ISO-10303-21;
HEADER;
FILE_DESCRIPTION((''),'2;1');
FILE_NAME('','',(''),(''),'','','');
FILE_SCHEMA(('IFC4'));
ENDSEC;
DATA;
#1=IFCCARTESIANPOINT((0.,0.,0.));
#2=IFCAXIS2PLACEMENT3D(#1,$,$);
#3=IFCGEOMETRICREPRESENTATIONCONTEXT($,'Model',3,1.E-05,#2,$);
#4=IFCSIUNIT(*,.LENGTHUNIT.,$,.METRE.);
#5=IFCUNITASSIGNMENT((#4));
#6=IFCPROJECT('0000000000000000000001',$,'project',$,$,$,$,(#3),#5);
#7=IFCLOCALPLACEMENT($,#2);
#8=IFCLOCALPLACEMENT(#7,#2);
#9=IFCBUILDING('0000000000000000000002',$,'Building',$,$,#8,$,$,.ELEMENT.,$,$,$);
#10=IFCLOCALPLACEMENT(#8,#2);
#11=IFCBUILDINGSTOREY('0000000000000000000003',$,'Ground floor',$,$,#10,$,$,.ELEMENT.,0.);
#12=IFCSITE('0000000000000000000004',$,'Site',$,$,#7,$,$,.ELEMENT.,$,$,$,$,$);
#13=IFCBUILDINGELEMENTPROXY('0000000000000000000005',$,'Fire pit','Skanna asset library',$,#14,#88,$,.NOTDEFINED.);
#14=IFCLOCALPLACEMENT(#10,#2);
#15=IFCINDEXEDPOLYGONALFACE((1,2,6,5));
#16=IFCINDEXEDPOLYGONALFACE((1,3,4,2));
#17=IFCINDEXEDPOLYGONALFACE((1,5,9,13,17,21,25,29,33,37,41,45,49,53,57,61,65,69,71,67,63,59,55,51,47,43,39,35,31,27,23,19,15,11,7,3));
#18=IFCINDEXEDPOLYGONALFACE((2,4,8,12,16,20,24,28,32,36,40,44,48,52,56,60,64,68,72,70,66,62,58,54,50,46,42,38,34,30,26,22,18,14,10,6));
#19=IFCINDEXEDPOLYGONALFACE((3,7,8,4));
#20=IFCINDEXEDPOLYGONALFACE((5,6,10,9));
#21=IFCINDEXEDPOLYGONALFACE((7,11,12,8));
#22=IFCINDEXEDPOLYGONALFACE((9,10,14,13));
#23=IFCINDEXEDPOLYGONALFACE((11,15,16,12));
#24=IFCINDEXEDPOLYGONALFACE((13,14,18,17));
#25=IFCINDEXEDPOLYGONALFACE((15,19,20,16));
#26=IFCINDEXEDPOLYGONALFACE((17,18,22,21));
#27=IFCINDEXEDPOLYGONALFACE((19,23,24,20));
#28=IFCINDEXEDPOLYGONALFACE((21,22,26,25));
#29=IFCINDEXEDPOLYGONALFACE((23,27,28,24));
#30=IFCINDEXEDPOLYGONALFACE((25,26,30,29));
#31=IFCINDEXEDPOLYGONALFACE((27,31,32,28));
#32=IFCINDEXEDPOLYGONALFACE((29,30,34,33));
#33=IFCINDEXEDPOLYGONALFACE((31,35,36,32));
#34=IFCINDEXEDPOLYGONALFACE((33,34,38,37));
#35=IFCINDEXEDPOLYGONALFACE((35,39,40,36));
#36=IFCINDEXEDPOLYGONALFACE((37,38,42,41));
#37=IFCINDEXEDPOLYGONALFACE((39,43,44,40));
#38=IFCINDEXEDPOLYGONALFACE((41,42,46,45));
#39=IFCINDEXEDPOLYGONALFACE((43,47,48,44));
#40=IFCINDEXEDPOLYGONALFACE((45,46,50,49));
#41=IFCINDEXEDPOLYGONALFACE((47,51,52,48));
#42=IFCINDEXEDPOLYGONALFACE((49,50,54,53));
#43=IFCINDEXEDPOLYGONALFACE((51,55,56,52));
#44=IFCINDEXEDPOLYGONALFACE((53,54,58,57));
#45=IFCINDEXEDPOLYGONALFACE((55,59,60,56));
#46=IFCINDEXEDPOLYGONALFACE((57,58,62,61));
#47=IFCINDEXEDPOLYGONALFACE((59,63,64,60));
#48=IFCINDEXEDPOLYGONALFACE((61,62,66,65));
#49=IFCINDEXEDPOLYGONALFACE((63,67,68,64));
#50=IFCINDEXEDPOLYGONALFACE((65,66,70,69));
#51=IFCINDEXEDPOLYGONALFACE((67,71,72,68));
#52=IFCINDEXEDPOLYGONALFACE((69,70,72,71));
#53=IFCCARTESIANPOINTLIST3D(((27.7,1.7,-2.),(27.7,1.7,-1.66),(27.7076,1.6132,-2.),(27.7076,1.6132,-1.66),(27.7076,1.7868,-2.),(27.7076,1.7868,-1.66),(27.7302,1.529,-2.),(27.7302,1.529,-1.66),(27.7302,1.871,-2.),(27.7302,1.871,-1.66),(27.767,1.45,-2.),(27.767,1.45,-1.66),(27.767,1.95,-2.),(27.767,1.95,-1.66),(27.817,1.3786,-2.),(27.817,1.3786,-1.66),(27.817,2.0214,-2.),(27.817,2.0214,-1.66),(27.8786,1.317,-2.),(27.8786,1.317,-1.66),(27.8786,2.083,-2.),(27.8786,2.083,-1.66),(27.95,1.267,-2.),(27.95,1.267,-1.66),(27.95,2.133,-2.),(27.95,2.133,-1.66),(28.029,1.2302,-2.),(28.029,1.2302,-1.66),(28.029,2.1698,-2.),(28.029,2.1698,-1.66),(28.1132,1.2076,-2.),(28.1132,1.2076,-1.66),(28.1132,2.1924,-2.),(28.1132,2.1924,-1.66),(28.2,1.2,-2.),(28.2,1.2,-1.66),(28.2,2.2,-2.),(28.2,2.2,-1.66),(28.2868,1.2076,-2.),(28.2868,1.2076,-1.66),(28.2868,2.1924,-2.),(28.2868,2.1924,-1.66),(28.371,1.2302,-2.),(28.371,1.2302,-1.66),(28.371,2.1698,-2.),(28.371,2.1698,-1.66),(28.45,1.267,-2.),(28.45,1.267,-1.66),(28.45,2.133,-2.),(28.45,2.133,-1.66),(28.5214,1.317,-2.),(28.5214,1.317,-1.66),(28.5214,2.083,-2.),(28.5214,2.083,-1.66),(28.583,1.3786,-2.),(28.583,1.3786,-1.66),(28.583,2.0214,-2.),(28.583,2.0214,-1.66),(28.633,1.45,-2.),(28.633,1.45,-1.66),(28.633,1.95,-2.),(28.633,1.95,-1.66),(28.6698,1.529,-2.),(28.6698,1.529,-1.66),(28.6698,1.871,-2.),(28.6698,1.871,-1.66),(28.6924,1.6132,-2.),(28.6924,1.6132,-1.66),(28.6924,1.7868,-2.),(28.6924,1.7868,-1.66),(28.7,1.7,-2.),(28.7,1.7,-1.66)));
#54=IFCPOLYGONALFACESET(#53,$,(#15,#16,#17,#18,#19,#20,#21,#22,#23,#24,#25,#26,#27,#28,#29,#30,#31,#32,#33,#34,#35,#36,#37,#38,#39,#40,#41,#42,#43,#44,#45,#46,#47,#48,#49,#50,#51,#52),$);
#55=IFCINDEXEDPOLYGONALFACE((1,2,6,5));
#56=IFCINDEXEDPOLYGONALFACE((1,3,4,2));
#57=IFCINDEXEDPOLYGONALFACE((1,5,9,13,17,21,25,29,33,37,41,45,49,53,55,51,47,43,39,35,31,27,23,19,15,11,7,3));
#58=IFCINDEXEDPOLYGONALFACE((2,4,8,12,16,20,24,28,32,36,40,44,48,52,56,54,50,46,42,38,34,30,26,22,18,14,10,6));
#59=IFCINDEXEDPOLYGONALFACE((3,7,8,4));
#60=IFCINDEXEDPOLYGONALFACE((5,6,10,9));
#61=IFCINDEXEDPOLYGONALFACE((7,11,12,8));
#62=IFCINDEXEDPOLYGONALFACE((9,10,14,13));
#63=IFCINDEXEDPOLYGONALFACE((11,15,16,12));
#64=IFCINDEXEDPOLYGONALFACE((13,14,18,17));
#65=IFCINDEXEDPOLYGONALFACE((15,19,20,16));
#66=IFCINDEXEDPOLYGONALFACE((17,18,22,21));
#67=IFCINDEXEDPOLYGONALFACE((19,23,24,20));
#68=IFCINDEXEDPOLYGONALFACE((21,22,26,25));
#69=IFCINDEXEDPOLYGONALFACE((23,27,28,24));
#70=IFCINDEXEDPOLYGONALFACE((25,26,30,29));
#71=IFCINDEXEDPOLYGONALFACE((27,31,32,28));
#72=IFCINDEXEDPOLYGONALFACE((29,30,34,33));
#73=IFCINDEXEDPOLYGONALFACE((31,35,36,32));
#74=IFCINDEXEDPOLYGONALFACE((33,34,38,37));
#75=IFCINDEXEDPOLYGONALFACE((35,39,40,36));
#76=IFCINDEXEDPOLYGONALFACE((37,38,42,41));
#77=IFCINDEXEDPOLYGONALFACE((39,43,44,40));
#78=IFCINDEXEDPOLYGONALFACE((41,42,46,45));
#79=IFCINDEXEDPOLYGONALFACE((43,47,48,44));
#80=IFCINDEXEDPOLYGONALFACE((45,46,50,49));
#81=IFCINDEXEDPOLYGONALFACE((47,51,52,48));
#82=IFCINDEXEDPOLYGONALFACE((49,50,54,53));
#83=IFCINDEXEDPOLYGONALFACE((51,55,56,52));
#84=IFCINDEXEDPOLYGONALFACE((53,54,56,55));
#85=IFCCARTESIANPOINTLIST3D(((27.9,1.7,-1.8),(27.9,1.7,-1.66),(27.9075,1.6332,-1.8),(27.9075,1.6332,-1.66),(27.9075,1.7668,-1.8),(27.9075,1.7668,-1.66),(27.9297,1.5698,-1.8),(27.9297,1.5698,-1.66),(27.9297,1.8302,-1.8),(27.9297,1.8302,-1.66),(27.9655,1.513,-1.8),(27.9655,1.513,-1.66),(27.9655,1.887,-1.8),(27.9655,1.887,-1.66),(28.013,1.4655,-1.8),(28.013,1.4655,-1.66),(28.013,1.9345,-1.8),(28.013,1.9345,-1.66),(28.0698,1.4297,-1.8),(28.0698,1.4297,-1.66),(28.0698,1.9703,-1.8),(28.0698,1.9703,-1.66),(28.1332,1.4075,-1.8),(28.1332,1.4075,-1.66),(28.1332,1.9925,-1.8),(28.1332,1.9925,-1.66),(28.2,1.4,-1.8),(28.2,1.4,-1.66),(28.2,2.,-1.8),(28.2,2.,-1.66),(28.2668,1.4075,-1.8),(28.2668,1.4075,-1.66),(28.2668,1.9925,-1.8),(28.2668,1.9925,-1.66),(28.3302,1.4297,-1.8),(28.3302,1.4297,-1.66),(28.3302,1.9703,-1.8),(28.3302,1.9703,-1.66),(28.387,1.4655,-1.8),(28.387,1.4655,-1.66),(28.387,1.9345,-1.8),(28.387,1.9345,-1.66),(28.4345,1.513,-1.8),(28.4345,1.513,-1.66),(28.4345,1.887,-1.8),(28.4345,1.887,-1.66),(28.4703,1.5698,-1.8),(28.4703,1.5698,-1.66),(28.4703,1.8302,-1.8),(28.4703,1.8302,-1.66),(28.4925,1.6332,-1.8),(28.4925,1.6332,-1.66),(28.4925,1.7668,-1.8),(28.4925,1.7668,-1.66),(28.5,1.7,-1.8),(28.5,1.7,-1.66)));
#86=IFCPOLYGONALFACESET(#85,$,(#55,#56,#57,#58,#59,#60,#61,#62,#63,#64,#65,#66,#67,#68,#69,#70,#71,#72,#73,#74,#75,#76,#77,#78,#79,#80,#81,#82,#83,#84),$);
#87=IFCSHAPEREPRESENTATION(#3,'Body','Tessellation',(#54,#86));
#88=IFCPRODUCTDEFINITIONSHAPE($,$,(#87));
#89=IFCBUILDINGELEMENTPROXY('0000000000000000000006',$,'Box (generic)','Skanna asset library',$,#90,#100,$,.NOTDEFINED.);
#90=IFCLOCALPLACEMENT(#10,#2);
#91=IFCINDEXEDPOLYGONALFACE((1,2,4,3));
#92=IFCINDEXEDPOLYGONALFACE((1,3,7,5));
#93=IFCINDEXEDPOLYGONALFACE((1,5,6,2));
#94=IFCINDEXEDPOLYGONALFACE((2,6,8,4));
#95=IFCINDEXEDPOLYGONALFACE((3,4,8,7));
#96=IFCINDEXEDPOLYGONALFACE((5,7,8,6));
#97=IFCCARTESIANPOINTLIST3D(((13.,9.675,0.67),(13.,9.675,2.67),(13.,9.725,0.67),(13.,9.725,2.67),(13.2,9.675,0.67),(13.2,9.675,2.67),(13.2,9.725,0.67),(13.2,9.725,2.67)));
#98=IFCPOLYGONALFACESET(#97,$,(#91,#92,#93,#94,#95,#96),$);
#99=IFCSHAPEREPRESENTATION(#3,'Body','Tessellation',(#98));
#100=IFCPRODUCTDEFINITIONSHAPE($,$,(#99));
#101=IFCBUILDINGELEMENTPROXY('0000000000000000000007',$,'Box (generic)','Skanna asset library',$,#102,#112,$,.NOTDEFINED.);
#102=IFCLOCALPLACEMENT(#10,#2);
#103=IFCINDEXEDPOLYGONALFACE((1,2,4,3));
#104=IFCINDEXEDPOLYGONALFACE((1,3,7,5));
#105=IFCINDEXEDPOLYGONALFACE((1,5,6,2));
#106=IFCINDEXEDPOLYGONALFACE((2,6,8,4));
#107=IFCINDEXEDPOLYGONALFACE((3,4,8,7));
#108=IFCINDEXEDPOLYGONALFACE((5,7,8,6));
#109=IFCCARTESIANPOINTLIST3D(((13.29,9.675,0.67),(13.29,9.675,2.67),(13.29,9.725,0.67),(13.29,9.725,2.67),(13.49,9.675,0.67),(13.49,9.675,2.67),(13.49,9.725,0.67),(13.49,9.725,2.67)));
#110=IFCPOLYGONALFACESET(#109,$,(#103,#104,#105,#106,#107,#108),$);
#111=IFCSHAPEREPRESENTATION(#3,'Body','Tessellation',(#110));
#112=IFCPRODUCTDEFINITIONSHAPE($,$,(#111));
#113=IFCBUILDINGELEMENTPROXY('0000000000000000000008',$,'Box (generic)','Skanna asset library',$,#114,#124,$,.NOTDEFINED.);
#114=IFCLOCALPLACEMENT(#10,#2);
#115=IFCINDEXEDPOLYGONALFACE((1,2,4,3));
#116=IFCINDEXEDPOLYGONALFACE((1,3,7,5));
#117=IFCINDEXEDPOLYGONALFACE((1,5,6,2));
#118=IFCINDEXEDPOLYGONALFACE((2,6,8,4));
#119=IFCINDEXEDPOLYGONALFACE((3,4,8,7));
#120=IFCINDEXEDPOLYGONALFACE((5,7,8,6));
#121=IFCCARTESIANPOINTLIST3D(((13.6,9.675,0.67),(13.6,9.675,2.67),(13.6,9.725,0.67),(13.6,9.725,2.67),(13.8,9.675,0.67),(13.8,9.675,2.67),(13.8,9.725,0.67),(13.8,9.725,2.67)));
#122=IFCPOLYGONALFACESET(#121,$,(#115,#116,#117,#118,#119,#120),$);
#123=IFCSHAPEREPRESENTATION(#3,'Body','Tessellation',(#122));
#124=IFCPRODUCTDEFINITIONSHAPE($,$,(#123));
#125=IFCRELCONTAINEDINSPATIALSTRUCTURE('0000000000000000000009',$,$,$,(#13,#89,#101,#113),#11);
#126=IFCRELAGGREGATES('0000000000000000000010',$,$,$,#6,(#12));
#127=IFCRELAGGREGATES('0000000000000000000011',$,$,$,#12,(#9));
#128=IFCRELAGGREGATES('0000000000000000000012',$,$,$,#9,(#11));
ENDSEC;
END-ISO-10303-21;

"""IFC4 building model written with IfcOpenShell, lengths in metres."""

from ifc_helpers import new_model, si_unit, frame, origin, origin_2d, place, context, project, spatial, rectangle, circle, extrude, element, save


model = new_model("IFC4")

# Units and contexts
model_context = context("Model", 3, precision=1e-05, world=origin())
ifc_project = project(units=[si_unit("LENGTHUNIT", "METRE")], contexts=[model_context])

# Site, building, storey
site_placement = place(None, origin())
site = spatial("IfcSite", under=ifc_project, at=site_placement, Name="Site", CompositionType="ELEMENT")
building_placement = place(site_placement, origin())
building = spatial("IfcBuilding", under=site, at=building_placement, Name="Building", CompositionType="ELEMENT")
storey_placement = place(building_placement, origin())
storey = spatial("IfcBuildingStorey", under=building, at=storey_placement, Name="Ground floor", CompositionType="ELEMENT", Elevation=0.0)

# Building element proxies
proxy_1_placement = place(storey_placement, frame((28.2, 1.7, -2.0), z_axis=(0.0, 0.0, 1.0), x_axis=(1.0, 0.0, 0.0)))
element("IfcBuildingElementProxy", 1, at=proxy_1_placement, inside=storey, Name="Fire pit", Description="Skanna asset library", PredefinedType="NOTDEFINED", context=model_context, shape_type="SweptSolid", body=[
    extrude(circle(Radius=0.5, at=origin_2d()), origin(), (0.0, 0.0, 1.0), 0.34),
    extrude(circle(Radius=0.3, at=origin_2d()), frame((0.0, 0.0, 0.2)), (0.0, 0.0, 1.0), 0.14),
])
for number, where, z_axis, x_axis, name in (
    (2, (13.1, 9.7, 0.67), (0.0, 0.0, 1.0), (1.0, 0.0, 0.0), "Box (generic)"),
    (3, (13.39, 9.7, 0.67), (0.0, 0.0, 1.0), (1.0, 0.0, 0.0), "Box (generic)"),
    (4, (13.7, 9.7, 0.67), (0.0, 0.0, 1.0), (1.0, 0.0, 0.0), "Box (generic)"),
):
    element("IfcBuildingElementProxy", number, at=place(storey_placement, frame(where, z_axis=z_axis, x_axis=x_axis)), inside=storey, Name=name, Description="Skanna asset library", PredefinedType="NOTDEFINED", context=model_context, shape_type="SweptSolid", body=[
        extrude(rectangle(XDim=0.2, YDim=0.05, at=origin_2d()), origin(), (0.0, 0.0, 1.0), 2.0),
    ])

save(model, "model.ifc")
